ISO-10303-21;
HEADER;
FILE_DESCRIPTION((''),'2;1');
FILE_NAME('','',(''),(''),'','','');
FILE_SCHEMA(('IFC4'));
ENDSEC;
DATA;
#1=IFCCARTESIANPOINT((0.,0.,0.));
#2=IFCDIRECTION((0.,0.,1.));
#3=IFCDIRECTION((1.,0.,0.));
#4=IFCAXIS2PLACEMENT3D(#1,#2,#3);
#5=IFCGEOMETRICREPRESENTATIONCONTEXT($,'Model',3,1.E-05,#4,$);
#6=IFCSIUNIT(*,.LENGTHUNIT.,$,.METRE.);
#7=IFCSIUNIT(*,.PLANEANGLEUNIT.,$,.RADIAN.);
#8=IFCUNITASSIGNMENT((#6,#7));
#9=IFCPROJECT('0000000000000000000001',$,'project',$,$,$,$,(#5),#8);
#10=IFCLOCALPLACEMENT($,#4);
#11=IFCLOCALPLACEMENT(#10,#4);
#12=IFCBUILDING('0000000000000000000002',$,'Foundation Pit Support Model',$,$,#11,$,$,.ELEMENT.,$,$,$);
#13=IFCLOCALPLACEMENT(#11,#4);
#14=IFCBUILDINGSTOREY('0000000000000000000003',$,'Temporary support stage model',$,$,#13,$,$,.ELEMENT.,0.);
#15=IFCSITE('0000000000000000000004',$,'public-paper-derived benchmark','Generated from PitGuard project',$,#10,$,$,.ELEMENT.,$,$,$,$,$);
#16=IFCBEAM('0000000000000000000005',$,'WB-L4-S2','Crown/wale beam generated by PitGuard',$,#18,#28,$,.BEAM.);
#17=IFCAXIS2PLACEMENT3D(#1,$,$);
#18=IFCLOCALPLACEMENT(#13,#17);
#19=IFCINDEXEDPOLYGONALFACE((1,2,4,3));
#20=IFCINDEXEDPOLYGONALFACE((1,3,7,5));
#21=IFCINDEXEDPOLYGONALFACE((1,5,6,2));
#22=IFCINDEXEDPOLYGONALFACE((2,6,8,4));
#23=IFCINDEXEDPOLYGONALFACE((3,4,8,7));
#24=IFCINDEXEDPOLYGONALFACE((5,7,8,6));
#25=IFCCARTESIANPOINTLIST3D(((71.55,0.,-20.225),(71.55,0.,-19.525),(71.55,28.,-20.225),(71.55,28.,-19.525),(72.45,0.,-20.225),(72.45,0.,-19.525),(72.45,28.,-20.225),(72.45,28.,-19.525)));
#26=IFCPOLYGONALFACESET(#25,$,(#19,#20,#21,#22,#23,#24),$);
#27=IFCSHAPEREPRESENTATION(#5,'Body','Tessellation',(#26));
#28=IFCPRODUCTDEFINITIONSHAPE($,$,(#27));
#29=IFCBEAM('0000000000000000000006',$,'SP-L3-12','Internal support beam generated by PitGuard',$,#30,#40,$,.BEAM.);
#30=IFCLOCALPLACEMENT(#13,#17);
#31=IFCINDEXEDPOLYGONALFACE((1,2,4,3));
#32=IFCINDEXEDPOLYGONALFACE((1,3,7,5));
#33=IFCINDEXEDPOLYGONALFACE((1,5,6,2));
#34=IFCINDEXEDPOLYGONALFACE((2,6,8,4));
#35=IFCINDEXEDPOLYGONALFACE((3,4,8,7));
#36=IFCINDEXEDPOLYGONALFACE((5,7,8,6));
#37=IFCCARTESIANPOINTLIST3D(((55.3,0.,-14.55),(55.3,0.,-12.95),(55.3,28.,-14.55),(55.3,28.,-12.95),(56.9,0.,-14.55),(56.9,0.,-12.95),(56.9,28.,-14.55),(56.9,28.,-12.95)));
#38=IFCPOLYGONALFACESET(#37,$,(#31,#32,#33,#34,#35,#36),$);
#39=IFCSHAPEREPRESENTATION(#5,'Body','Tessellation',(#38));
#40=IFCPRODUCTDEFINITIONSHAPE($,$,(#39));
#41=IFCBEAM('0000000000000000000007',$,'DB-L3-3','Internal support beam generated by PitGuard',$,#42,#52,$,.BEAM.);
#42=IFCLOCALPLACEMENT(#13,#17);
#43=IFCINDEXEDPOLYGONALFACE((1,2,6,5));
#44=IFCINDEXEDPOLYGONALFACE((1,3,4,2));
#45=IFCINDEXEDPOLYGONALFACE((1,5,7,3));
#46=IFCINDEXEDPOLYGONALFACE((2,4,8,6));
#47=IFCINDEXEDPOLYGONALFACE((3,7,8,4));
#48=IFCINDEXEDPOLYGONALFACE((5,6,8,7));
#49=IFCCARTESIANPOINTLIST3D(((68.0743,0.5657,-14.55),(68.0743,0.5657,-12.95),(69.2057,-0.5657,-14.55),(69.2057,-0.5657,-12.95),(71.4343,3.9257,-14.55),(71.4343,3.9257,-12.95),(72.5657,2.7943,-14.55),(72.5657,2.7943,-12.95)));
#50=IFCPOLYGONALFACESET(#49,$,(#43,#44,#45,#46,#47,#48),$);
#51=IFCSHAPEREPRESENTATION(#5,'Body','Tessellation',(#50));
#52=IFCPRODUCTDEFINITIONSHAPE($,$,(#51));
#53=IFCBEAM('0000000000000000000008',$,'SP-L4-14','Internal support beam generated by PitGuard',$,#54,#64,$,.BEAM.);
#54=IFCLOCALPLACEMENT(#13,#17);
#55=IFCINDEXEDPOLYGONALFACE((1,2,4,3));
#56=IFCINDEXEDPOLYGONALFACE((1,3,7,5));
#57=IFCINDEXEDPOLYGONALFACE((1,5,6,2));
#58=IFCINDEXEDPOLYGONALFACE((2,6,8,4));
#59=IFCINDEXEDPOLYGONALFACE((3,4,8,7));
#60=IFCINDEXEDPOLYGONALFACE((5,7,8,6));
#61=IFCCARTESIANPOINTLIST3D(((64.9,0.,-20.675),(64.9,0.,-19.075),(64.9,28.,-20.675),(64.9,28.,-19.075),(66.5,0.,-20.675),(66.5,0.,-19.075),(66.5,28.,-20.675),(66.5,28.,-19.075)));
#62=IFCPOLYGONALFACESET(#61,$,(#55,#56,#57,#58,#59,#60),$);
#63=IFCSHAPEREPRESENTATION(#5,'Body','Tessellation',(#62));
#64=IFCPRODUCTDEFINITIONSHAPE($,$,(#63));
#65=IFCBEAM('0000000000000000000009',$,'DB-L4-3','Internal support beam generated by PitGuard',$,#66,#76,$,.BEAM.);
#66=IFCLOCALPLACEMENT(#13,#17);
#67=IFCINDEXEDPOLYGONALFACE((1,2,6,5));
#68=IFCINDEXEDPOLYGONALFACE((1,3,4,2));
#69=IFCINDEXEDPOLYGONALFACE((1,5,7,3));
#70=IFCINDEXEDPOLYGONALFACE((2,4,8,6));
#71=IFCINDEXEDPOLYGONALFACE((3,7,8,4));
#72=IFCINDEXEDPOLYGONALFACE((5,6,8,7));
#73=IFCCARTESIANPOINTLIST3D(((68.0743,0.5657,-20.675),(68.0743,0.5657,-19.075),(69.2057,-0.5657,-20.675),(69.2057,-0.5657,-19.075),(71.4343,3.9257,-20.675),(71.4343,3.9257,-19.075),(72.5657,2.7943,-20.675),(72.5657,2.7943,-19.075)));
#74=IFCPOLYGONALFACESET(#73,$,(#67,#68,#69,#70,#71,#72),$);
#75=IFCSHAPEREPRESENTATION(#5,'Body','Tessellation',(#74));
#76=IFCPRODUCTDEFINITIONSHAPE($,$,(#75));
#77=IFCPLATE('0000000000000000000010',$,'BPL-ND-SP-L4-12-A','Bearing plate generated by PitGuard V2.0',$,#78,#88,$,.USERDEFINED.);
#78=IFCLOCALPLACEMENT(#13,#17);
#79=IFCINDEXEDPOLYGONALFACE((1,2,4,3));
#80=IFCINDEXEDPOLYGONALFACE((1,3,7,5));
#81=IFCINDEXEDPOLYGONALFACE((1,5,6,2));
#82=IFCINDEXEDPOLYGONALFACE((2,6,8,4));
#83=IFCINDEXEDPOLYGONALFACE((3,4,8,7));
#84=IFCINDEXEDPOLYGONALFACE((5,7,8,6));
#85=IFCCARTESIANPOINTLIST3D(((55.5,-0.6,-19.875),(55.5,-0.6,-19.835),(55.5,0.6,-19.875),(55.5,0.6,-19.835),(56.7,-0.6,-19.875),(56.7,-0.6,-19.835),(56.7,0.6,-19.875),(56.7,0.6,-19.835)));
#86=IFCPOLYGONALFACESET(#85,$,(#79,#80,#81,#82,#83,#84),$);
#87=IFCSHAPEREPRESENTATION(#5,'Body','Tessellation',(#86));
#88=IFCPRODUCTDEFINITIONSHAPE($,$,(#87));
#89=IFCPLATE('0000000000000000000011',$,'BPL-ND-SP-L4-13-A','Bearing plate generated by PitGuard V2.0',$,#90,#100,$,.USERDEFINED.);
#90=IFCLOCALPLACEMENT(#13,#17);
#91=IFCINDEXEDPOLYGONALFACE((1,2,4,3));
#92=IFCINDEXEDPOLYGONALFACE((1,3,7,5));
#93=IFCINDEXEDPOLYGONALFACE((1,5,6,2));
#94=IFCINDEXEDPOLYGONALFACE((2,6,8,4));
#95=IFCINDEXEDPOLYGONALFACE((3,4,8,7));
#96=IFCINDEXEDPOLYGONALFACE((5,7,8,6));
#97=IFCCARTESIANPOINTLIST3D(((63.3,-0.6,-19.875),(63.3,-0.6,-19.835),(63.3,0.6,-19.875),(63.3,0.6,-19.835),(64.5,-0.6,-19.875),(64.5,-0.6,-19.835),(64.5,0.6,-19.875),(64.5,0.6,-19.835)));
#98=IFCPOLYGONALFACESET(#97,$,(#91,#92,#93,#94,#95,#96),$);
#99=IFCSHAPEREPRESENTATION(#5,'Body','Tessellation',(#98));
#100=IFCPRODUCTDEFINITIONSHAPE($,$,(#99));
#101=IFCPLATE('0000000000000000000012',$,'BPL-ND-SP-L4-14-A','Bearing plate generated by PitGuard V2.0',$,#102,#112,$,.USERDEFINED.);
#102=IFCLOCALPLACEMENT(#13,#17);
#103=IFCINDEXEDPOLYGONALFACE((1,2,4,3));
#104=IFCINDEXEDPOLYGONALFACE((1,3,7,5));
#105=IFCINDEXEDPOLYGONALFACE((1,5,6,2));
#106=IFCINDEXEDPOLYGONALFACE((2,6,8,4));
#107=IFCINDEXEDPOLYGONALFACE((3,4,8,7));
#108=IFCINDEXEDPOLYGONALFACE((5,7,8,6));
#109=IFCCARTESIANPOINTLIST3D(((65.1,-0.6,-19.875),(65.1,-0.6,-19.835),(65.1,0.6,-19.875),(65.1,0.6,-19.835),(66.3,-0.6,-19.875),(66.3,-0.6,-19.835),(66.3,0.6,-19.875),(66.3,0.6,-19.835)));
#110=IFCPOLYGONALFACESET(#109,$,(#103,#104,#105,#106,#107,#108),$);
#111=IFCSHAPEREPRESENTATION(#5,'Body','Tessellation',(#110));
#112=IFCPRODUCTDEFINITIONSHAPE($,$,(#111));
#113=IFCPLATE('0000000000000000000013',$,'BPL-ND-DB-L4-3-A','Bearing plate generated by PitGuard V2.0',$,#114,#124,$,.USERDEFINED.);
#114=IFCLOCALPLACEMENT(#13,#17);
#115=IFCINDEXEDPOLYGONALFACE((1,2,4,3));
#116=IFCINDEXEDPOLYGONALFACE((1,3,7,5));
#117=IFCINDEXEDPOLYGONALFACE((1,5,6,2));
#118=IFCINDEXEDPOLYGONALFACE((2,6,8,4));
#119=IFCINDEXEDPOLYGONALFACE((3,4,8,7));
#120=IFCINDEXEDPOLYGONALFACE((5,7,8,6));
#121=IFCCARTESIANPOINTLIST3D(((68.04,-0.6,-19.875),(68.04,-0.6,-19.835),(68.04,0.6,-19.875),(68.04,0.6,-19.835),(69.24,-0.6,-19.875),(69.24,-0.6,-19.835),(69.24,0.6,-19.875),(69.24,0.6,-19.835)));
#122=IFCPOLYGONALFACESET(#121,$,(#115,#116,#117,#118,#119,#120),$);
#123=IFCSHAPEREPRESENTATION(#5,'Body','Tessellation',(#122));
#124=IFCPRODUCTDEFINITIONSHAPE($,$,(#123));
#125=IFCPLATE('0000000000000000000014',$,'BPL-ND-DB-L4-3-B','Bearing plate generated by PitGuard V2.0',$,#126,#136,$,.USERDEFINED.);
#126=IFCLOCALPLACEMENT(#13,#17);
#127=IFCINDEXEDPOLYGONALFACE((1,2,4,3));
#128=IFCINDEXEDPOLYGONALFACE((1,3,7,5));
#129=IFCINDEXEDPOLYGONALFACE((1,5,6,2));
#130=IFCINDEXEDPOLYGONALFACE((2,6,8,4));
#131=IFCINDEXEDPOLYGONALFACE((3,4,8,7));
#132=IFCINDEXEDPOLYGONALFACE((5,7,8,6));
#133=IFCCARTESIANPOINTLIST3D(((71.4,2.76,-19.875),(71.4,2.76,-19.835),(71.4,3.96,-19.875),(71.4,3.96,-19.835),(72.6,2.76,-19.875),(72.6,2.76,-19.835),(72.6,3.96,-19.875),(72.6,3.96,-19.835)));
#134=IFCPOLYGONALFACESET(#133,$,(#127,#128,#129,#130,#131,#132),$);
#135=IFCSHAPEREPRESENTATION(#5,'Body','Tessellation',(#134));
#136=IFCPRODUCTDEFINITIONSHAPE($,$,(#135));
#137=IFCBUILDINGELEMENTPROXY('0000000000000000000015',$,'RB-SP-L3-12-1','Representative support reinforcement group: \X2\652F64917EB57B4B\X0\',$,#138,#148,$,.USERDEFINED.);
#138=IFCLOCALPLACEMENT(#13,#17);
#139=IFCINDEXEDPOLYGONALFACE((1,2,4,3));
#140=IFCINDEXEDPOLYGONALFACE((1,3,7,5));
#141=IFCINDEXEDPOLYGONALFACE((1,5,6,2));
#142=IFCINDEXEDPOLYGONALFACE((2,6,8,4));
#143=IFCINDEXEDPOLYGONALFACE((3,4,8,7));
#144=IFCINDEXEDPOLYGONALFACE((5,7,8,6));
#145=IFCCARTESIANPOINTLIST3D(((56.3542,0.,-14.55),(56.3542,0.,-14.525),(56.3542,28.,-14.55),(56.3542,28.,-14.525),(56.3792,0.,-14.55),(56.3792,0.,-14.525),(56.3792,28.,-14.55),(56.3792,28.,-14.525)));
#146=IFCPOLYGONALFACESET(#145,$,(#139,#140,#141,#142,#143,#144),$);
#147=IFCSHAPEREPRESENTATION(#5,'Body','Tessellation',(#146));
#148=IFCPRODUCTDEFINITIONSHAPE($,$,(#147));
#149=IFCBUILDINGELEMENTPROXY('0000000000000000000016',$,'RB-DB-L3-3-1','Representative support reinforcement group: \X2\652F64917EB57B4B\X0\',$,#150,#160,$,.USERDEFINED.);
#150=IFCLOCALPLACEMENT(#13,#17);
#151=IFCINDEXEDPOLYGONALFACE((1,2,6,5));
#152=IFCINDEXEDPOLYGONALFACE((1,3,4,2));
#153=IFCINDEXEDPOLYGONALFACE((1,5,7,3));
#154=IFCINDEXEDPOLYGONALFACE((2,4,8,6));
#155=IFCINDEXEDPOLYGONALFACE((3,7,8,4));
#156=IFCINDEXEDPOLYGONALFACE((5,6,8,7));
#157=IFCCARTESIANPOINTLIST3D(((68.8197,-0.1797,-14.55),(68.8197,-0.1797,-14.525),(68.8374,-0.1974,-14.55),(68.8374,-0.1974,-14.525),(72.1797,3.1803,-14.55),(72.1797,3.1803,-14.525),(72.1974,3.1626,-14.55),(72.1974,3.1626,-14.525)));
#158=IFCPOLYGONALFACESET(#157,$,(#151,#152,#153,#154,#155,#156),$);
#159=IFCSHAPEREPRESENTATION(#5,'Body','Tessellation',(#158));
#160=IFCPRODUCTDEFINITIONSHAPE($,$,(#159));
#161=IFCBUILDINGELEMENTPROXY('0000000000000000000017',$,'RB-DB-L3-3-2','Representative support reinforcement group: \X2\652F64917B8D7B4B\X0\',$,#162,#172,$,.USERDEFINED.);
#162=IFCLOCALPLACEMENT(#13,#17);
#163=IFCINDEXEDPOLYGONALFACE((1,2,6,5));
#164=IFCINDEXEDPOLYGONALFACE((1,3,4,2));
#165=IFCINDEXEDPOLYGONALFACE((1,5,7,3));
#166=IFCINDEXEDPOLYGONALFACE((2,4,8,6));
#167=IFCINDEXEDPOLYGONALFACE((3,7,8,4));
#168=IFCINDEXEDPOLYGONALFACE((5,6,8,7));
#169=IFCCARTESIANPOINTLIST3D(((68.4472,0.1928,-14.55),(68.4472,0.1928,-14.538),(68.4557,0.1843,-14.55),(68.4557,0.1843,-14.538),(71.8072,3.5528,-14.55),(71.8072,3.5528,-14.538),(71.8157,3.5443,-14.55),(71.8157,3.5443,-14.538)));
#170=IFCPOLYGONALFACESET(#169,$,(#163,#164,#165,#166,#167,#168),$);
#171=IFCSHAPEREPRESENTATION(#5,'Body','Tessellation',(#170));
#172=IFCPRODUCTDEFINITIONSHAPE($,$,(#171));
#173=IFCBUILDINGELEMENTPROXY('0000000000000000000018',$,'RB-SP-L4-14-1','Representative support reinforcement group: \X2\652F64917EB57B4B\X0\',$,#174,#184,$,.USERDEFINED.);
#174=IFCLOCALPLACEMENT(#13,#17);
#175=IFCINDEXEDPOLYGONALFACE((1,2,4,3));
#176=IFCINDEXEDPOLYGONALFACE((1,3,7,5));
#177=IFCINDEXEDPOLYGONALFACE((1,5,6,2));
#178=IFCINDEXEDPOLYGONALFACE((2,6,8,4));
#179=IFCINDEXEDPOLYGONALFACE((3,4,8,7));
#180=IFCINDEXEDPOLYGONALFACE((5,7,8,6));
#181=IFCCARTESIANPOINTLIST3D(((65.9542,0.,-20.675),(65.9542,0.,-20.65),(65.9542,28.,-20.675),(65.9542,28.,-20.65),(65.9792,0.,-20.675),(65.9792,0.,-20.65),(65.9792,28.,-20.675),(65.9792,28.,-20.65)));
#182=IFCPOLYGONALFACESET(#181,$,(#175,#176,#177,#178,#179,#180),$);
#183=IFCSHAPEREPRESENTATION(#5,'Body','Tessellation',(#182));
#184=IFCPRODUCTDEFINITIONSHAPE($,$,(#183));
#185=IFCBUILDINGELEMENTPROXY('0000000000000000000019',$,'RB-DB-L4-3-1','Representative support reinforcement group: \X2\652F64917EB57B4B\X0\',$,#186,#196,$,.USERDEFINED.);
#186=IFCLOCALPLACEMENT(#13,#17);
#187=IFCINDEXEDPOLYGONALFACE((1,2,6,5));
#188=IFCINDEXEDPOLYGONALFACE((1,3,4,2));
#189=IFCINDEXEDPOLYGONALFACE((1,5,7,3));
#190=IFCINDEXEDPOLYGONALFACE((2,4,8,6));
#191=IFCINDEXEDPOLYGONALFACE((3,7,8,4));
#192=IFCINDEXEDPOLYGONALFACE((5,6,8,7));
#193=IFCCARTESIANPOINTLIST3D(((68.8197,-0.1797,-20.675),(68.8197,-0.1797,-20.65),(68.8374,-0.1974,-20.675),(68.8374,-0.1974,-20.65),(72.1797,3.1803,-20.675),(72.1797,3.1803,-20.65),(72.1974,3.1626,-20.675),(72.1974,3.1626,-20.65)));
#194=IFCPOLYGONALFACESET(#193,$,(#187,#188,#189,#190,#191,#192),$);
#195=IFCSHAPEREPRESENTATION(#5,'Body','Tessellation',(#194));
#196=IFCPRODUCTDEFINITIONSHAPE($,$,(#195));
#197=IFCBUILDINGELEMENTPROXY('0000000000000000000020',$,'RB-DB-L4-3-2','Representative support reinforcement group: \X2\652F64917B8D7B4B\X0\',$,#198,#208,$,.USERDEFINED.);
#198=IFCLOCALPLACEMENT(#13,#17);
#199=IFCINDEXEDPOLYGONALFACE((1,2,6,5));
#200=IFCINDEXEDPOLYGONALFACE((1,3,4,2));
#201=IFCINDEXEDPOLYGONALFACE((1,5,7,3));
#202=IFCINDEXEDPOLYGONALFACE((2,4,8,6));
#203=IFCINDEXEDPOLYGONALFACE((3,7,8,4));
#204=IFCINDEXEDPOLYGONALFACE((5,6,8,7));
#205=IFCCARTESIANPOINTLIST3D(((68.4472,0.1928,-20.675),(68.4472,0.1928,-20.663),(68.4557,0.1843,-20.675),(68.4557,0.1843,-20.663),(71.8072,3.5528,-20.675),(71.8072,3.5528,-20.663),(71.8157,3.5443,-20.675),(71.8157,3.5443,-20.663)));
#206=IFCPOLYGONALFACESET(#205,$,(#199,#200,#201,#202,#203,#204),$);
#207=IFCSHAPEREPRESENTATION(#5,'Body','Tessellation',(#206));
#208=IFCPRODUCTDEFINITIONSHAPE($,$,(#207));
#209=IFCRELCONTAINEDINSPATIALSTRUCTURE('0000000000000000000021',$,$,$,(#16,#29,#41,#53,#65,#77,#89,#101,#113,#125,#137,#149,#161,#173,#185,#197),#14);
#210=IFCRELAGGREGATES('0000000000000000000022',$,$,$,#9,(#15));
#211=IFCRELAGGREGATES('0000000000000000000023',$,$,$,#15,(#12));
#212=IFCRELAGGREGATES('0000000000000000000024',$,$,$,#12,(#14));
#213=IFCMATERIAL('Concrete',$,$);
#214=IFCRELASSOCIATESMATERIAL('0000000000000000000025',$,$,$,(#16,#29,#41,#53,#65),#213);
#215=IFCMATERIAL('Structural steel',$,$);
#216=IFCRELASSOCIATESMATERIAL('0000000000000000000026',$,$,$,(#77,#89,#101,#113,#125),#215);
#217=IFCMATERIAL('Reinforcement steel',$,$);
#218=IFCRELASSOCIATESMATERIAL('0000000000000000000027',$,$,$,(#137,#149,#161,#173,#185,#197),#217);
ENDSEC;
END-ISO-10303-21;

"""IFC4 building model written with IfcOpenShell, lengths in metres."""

from ifc_helpers import new_model, si_unit, frame, origin_with_axes, origin_2d, place, context, project, spatial, rectangle, extrude, material, element, save


model = new_model("IFC4")

# Units and contexts
model_context = context("Model", 3, precision=1e-05, world=origin_with_axes())
ifc_project = project(units=[si_unit("LENGTHUNIT", "METRE"), si_unit("PLANEANGLEUNIT", "RADIAN")], contexts=[model_context])

# Site, building, storey
site_placement = place(None, origin_with_axes())
site = spatial("IfcSite", under=ifc_project, at=site_placement, Name="public-paper-derived benchmark", Description="Generated from PitGuard project", CompositionType="ELEMENT")
building_placement = place(site_placement, origin_with_axes())
building = spatial("IfcBuilding", under=site, at=building_placement, Name="Foundation Pit Support Model", CompositionType="ELEMENT")
storey_placement = place(building_placement, origin_with_axes())
storey = spatial("IfcBuildingStorey", under=building, at=storey_placement, Name="Temporary support stage model", CompositionType="ELEMENT", Elevation=0.0)

# Beams
ifc_material_1 = material(Name="Concrete")
beam_1_placement = place(storey_placement, frame((72.0, 14.0, -20.225), z_axis=(0.0, 0.0, 1.0), x_axis=(0.0, 1.0, 0.0)))
element("IfcBeam", 1, at=beam_1_placement, inside=storey, material=ifc_material_1, Name="WB-L4-S2", Description="Crown/wale beam generated by PitGuard", PredefinedType="BEAM", context=model_context, shape_type="SweptSolid", body=[
    extrude(rectangle(XDim=28.0, YDim=0.9, at=origin_2d()), origin_with_axes(), (0.0, 0.0, 1.0), 0.7),
])
beam_2_placement = place(storey_placement, frame((56.1, 14.0, -14.55), z_axis=(0.0, 0.0, 1.0), x_axis=(0.0, 1.0, 0.0)))
element("IfcBeam", 2, at=beam_2_placement, inside=storey, material=ifc_material_1, Name="SP-L3-12", Description="Internal support beam generated by PitGuard", PredefinedType="BEAM", context=model_context, shape_type="SweptSolid", body=[
    extrude(rectangle(XDim=28.0, YDim=1.6, at=origin_2d()), origin_with_axes(), (0.0, 0.0, 1.0), 1.6),
])
beam_3_placement = place(storey_placement, frame((70.32, 1.68, -14.55), z_axis=(0.0, 0.0, 1.0), x_axis=(0.707107, 0.707107, 0.0)))
element("IfcBeam", 3, at=beam_3_placement, inside=storey, material=ifc_material_1, Name="DB-L3-3", Description="Internal support beam generated by PitGuard", PredefinedType="BEAM", context=model_context, shape_type="SweptSolid", body=[
    extrude(rectangle(XDim=4.7518, YDim=1.6, at=origin_2d()), origin_with_axes(), (0.0, 0.0, 1.0), 1.6),
])
beam_4_placement = place(storey_placement, frame((65.7, 14.0, -20.675), z_axis=(0.0, 0.0, 1.0), x_axis=(0.0, 1.0, 0.0)))
element("IfcBeam", 4, at=beam_4_placement, inside=storey, material=ifc_material_1, Name="SP-L4-14", Description="Internal support beam generated by PitGuard", PredefinedType="BEAM", context=model_context, shape_type="SweptSolid", body=[
    extrude(rectangle(XDim=28.0, YDim=1.6, at=origin_2d()), origin_with_axes(), (0.0, 0.0, 1.0), 1.6),
])
beam_5_placement = place(storey_placement, frame((70.32, 1.68, -20.675), z_axis=(0.0, 0.0, 1.0), x_axis=(0.707107, 0.707107, 0.0)))
element("IfcBeam", 5, at=beam_5_placement, inside=storey, material=ifc_material_1, Name="DB-L4-3", Description="Internal support beam generated by PitGuard", PredefinedType="BEAM", context=model_context, shape_type="SweptSolid", body=[
    extrude(rectangle(XDim=4.7518, YDim=1.6, at=origin_2d()), origin_with_axes(), (0.0, 0.0, 1.0), 1.6),
])

# Plates
ifc_material_2 = material(Name="Structural steel")
for number, where, z_axis, x_axis, name in (
    (6, (56.1, 0.0, -19.875), (0.0, 0.0, 1.0), (1.0, 0.0, 0.0), "BPL-ND-SP-L4-12-A"),
    (7, (63.9, 0.0, -19.875), (0.0, 0.0, 1.0), (1.0, 0.0, 0.0), "BPL-ND-SP-L4-13-A"),
    (8, (65.7, 0.0, -19.875), (0.0, 0.0, 1.0), (1.0, 0.0, 0.0), "BPL-ND-SP-L4-14-A"),
    (9, (68.64, 0.0, -19.875), (0.0, 0.0, 1.0), (1.0, 0.0, 0.0), "BPL-ND-DB-L4-3-A"),
    (10, (72.0, 3.36, -19.875), (0.0, 0.0, 1.0), (1.0, 0.0, 0.0), "BPL-ND-DB-L4-3-B"),
):
    element("IfcPlate", number, at=place(storey_placement, frame(where, z_axis=z_axis, x_axis=x_axis)), inside=storey, material=ifc_material_2, Name=name, Description="Bearing plate generated by PitGuard V2.0", PredefinedType="USERDEFINED", context=model_context, shape_type="SweptSolid", body=[
        extrude(rectangle(XDim=1.2, YDim=1.2, at=origin_2d()), origin_with_axes(), (0.0, 0.0, 1.0), 0.04),
    ])

# Building element proxies
ifc_material_3 = material(Name="Reinforcement steel")
proxy_1_placement = place(storey_placement, frame((56.3667, 14.0, -14.55), z_axis=(0.0, 0.0, 1.0), x_axis=(0.0, 1.0, 0.0)))
element("IfcBuildingElementProxy", 11, at=proxy_1_placement, inside=storey, material=ifc_material_3, Name="RB-SP-L3-12-1", Description="Representative support reinforcement group: 支撑纵筋", PredefinedType="USERDEFINED", context=model_context, shape_type="SweptSolid", body=[
    extrude(rectangle(XDim=28.0, YDim=0.025, at=origin_2d()), origin_with_axes(), (0.0, 0.0, 1.0), 0.025),
])
proxy_2_placement = place(storey_placement, frame((70.5086, 1.4914, -14.55), z_axis=(0.0, 0.0, 1.0), x_axis=(0.707107, 0.707107, 0.0)))
element("IfcBuildingElementProxy", 12, at=proxy_2_placement, inside=storey, material=ifc_material_3, Name="RB-DB-L3-3-1", Description="Representative support reinforcement group: 支撑纵筋", PredefinedType="USERDEFINED", context=model_context, shape_type="SweptSolid", body=[
    extrude(rectangle(XDim=4.7518, YDim=0.025, at=origin_2d()), origin_with_axes(), (0.0, 0.0, 1.0), 0.025),
])
proxy_3_placement = place(storey_placement, frame((70.1314, 1.8686, -14.55), z_axis=(0.0, 0.0, 1.0), x_axis=(0.707107, 0.707107, 0.0)))
element("IfcBuildingElementProxy", 13, at=proxy_3_placement, inside=storey, material=ifc_material_3, Name="RB-DB-L3-3-2", Description="Representative support reinforcement group: 支撑箍筋", PredefinedType="USERDEFINED", context=model_context, shape_type="SweptSolid", body=[
    extrude(rectangle(XDim=4.7518, YDim=0.012, at=origin_2d()), origin_with_axes(), (0.0, 0.0, 1.0), 0.012),
])
proxy_4_placement = place(storey_placement, frame((65.9667, 14.0, -20.675), z_axis=(0.0, 0.0, 1.0), x_axis=(0.0, 1.0, 0.0)))
element("IfcBuildingElementProxy", 14, at=proxy_4_placement, inside=storey, material=ifc_material_3, Name="RB-SP-L4-14-1", Description="Representative support reinforcement group: 支撑纵筋", PredefinedType="USERDEFINED", context=model_context, shape_type="SweptSolid", body=[
    extrude(rectangle(XDim=28.0, YDim=0.025, at=origin_2d()), origin_with_axes(), (0.0, 0.0, 1.0), 0.025),
])
proxy_5_placement = place(storey_placement, frame((70.5086, 1.4914, -20.675), z_axis=(0.0, 0.0, 1.0), x_axis=(0.707107, 0.707107, 0.0)))
element("IfcBuildingElementProxy", 15, at=proxy_5_placement, inside=storey, material=ifc_material_3, Name="RB-DB-L4-3-1", Description="Representative support reinforcement group: 支撑纵筋", PredefinedType="USERDEFINED", context=model_context, shape_type="SweptSolid", body=[
    extrude(rectangle(XDim=4.7518, YDim=0.025, at=origin_2d()), origin_with_axes(), (0.0, 0.0, 1.0), 0.025),
])
proxy_6_placement = place(storey_placement, frame((70.1314, 1.8686, -20.675), z_axis=(0.0, 0.0, 1.0), x_axis=(0.707107, 0.707107, 0.0)))
element("IfcBuildingElementProxy", 16, at=proxy_6_placement, inside=storey, material=ifc_material_3, Name="RB-DB-L4-3-2", Description="Representative support reinforcement group: 支撑箍筋", PredefinedType="USERDEFINED", context=model_context, shape_type="SweptSolid", body=[
    extrude(rectangle(XDim=4.7518, YDim=0.012, at=origin_2d()), origin_with_axes(), (0.0, 0.0, 1.0), 0.012),
])

save(model, "model.ifc")
